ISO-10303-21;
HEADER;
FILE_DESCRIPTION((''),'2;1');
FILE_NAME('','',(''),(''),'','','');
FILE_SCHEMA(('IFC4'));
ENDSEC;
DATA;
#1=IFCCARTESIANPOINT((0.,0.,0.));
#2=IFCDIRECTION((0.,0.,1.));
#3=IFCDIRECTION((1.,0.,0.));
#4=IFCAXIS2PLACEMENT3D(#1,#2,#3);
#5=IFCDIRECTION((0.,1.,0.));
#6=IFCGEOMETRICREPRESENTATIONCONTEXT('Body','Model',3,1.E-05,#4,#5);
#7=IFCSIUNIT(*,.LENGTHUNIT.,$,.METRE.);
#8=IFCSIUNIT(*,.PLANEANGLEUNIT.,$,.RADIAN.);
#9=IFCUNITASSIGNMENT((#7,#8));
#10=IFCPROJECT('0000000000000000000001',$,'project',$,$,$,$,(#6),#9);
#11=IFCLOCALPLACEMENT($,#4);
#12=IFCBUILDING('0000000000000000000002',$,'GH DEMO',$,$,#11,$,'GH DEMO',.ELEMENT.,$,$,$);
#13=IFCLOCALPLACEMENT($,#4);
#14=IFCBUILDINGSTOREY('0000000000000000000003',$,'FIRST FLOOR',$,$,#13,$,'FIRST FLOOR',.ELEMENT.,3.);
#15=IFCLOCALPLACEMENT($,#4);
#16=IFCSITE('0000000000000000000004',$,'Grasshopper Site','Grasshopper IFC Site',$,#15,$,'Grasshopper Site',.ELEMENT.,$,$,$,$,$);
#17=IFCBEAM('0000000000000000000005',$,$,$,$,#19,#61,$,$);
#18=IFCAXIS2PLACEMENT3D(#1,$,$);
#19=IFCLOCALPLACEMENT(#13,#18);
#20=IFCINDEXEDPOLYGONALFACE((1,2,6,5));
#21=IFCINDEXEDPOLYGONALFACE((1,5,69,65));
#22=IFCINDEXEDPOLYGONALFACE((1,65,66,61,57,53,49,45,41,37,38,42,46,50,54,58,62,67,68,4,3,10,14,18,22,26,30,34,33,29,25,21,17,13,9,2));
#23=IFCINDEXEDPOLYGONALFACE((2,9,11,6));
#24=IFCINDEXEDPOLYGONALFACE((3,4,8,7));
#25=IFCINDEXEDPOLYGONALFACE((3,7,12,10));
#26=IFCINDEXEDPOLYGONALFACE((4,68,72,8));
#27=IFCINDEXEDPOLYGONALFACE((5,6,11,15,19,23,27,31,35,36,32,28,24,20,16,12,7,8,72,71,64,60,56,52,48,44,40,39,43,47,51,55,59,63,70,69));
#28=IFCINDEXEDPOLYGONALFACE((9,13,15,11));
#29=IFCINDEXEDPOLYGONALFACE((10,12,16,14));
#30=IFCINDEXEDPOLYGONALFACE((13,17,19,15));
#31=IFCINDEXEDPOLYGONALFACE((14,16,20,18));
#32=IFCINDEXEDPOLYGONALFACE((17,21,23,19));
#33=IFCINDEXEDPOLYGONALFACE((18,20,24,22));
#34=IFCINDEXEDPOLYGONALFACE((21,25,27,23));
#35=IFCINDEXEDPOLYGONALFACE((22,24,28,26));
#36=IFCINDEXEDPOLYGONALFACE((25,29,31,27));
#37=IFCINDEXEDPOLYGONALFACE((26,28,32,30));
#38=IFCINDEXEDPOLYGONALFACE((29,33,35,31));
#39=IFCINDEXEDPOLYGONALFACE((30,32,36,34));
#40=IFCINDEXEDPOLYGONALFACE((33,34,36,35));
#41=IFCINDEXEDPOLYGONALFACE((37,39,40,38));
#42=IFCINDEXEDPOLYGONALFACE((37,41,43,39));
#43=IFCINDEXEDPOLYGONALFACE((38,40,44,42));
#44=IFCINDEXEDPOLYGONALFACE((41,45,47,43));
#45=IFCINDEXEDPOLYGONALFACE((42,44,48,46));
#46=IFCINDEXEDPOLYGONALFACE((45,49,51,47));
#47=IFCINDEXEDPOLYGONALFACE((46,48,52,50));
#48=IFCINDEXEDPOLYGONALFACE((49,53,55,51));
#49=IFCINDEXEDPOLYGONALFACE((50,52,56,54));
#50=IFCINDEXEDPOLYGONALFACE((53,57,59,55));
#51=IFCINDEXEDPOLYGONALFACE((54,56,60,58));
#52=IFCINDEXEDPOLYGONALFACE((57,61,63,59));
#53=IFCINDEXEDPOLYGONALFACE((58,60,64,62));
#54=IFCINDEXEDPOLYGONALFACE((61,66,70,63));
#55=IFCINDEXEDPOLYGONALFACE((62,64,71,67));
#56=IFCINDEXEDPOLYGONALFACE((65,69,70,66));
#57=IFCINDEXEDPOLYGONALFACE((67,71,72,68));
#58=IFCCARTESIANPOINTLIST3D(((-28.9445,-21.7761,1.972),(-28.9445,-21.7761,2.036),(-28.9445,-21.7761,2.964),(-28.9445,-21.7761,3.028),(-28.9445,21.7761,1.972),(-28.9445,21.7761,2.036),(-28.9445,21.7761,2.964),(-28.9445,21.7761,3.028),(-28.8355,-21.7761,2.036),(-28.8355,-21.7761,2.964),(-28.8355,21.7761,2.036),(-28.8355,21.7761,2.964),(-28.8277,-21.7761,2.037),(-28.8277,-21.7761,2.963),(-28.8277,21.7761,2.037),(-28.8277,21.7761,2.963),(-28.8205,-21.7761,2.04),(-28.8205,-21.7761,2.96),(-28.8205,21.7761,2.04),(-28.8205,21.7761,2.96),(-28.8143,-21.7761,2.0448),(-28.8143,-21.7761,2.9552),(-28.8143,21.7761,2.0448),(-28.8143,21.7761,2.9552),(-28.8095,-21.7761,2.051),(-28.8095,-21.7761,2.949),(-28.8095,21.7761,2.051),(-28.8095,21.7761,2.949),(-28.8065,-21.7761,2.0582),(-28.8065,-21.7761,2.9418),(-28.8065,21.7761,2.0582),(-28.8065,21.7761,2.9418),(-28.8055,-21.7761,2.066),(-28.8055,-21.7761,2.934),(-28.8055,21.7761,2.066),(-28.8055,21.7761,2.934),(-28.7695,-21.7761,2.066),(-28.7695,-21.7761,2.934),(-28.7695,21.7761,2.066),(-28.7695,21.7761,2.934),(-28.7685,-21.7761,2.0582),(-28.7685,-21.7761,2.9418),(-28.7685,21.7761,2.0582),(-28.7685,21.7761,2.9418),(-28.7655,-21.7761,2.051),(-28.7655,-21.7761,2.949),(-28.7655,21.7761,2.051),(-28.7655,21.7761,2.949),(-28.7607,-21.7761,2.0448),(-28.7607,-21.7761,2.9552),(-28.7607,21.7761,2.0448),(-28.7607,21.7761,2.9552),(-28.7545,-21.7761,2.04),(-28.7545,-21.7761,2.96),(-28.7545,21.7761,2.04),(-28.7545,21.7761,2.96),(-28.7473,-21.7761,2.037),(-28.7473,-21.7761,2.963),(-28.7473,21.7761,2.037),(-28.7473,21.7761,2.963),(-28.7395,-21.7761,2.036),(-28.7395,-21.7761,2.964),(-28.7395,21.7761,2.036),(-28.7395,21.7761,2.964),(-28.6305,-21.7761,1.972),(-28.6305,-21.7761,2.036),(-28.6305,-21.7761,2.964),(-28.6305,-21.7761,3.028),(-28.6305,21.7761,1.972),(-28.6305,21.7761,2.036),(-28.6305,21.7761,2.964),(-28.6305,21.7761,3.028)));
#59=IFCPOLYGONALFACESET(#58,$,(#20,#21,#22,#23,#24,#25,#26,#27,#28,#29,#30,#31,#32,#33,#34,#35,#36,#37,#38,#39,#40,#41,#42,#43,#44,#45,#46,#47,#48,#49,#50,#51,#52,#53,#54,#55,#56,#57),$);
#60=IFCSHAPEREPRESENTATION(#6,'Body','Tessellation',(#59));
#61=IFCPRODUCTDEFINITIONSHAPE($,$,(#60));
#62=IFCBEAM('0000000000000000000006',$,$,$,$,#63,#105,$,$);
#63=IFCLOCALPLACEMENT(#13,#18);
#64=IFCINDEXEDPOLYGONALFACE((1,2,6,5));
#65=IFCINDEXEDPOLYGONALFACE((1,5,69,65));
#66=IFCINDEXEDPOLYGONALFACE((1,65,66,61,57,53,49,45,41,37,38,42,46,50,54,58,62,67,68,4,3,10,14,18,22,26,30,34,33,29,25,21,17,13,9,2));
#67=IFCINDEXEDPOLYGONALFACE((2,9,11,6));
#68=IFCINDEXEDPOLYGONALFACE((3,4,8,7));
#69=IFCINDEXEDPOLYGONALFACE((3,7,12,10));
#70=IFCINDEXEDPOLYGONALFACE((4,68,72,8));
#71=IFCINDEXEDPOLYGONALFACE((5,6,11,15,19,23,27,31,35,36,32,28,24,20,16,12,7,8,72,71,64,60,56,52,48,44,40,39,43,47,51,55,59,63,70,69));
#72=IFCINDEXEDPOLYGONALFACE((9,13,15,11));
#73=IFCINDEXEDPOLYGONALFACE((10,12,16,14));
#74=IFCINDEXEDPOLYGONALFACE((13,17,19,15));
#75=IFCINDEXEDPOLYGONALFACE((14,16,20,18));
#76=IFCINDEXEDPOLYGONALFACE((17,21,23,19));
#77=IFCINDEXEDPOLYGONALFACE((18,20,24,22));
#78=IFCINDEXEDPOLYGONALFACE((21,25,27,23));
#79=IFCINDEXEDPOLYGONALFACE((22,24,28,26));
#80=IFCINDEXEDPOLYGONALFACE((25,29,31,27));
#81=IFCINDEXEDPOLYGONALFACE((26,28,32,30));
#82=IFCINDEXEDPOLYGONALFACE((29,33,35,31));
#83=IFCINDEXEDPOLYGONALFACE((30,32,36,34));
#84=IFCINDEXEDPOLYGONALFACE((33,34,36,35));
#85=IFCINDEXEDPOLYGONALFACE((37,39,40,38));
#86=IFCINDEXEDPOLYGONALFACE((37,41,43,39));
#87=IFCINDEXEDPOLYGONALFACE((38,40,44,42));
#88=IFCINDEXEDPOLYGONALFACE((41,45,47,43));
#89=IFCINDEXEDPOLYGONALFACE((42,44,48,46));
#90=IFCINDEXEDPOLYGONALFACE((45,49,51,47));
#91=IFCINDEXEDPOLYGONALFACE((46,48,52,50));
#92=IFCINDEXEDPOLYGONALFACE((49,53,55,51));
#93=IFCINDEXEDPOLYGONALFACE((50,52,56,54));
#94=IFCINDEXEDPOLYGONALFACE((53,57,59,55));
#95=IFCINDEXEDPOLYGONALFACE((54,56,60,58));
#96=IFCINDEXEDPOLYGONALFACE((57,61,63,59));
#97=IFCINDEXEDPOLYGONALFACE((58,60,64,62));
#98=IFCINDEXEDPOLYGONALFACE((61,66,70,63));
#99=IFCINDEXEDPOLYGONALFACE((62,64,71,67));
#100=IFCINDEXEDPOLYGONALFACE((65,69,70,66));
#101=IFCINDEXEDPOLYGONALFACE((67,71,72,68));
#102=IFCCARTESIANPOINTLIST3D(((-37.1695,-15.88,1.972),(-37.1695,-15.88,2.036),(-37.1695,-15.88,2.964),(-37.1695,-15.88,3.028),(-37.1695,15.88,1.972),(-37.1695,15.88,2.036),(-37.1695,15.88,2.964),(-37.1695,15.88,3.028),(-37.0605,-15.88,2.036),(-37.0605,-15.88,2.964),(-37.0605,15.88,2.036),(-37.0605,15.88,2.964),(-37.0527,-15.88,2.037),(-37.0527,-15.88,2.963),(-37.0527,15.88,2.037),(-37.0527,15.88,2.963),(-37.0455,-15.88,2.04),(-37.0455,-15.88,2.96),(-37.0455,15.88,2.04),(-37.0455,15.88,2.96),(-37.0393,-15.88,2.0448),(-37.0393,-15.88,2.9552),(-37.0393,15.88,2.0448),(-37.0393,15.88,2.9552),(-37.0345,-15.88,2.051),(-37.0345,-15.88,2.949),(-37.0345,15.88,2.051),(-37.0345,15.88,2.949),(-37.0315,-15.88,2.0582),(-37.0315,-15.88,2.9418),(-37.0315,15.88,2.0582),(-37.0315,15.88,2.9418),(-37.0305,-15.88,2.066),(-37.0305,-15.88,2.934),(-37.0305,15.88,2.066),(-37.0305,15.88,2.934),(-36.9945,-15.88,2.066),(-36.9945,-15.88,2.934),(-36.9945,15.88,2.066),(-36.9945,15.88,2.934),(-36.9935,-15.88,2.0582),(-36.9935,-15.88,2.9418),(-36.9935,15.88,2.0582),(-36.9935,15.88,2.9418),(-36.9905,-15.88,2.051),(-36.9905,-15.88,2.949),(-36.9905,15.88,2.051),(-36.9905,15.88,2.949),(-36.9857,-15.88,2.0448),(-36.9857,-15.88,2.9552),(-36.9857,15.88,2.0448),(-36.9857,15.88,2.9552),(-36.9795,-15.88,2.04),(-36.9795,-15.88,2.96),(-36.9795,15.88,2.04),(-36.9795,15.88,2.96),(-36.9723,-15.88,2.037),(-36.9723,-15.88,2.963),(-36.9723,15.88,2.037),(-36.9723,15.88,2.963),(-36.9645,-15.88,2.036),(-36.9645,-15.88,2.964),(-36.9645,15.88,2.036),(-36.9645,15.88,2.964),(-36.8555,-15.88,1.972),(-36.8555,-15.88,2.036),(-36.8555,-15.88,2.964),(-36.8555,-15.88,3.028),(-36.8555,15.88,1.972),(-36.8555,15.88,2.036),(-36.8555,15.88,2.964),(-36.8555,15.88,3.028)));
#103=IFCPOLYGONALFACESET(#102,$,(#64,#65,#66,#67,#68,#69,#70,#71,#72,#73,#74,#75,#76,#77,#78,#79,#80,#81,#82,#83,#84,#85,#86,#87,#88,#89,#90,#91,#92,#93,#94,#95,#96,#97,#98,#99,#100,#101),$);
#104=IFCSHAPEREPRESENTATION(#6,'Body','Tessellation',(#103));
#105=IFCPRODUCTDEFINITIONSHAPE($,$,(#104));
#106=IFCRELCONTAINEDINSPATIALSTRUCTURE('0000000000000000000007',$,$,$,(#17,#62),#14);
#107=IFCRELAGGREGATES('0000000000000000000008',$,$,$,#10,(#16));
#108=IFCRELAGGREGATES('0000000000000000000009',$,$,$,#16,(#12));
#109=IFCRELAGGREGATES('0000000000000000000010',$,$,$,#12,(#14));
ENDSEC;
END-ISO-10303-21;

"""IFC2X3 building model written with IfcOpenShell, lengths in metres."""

from ifc_helpers import new_model, si_unit, direction, frame, origin_with_axes, origin_2d, place, context, project, spatial, i_section, extrude, element, save


model = new_model("IFC2X3")

# Units and contexts
model_context = context("Model", 3, precision=1e-05, world=origin_with_axes(), true_north=direction((0.0, 1.0, 0.0)), identifier="Body")
ifc_project = project(units=[si_unit("LENGTHUNIT", "METRE"), si_unit("PLANEANGLEUNIT", "RADIAN")], contexts=[model_context])

# Site, building, storey
site_placement = place(None, origin_with_axes())
site = spatial("IfcSite", under=ifc_project, at=site_placement, Name="Grasshopper Site", Description="Grasshopper IFC Site", LongName="Grasshopper Site", CompositionType="ELEMENT")
building_placement = place(None, origin_with_axes())
building = spatial("IfcBuilding", under=site, at=building_placement, Name="GH DEMO", LongName="GH DEMO", CompositionType="ELEMENT")
storey_placement = place(None, origin_with_axes())
storey = spatial("IfcBuildingStorey", under=building, at=storey_placement, Name="FIRST FLOOR", LongName="FIRST FLOOR", CompositionType="ELEMENT", Elevation=3.0)

# Beams
beam_1_placement = place(None, origin_with_axes())
element("IfcBeam", 1, at=beam_1_placement, inside=storey, context=model_context, shape_type="SweptSolid", body=[
    extrude(i_section(OverallWidth=0.314, OverallDepth=1.056, WebThickness=0.036, FlangeThickness=0.064, FilletRadius=0.03, at=origin_2d()), frame((-28.7875, -21.7761, 2.5), z_axis=(0.0, 1.0, 0.0), x_axis=(-1.0, 0.0, 0.0)), (0.0, 0.0, 1.0), 43.5521),
])
beam_2_placement = place(None, origin_with_axes())
element("IfcBeam", 2, at=beam_2_placement, inside=storey, context=model_context, shape_type="SweptSolid", body=[
    extrude(i_section(OverallWidth=0.314, OverallDepth=1.056, WebThickness=0.036, FlangeThickness=0.064, FilletRadius=0.03, at=origin_2d()), frame((-37.0125, -15.88, 2.5), z_axis=(0.0, 1.0, 0.0), x_axis=(-1.0, 0.0, 0.0)), (0.0, 0.0, 1.0), 31.7599),
])

save(model, "model.ifc")
